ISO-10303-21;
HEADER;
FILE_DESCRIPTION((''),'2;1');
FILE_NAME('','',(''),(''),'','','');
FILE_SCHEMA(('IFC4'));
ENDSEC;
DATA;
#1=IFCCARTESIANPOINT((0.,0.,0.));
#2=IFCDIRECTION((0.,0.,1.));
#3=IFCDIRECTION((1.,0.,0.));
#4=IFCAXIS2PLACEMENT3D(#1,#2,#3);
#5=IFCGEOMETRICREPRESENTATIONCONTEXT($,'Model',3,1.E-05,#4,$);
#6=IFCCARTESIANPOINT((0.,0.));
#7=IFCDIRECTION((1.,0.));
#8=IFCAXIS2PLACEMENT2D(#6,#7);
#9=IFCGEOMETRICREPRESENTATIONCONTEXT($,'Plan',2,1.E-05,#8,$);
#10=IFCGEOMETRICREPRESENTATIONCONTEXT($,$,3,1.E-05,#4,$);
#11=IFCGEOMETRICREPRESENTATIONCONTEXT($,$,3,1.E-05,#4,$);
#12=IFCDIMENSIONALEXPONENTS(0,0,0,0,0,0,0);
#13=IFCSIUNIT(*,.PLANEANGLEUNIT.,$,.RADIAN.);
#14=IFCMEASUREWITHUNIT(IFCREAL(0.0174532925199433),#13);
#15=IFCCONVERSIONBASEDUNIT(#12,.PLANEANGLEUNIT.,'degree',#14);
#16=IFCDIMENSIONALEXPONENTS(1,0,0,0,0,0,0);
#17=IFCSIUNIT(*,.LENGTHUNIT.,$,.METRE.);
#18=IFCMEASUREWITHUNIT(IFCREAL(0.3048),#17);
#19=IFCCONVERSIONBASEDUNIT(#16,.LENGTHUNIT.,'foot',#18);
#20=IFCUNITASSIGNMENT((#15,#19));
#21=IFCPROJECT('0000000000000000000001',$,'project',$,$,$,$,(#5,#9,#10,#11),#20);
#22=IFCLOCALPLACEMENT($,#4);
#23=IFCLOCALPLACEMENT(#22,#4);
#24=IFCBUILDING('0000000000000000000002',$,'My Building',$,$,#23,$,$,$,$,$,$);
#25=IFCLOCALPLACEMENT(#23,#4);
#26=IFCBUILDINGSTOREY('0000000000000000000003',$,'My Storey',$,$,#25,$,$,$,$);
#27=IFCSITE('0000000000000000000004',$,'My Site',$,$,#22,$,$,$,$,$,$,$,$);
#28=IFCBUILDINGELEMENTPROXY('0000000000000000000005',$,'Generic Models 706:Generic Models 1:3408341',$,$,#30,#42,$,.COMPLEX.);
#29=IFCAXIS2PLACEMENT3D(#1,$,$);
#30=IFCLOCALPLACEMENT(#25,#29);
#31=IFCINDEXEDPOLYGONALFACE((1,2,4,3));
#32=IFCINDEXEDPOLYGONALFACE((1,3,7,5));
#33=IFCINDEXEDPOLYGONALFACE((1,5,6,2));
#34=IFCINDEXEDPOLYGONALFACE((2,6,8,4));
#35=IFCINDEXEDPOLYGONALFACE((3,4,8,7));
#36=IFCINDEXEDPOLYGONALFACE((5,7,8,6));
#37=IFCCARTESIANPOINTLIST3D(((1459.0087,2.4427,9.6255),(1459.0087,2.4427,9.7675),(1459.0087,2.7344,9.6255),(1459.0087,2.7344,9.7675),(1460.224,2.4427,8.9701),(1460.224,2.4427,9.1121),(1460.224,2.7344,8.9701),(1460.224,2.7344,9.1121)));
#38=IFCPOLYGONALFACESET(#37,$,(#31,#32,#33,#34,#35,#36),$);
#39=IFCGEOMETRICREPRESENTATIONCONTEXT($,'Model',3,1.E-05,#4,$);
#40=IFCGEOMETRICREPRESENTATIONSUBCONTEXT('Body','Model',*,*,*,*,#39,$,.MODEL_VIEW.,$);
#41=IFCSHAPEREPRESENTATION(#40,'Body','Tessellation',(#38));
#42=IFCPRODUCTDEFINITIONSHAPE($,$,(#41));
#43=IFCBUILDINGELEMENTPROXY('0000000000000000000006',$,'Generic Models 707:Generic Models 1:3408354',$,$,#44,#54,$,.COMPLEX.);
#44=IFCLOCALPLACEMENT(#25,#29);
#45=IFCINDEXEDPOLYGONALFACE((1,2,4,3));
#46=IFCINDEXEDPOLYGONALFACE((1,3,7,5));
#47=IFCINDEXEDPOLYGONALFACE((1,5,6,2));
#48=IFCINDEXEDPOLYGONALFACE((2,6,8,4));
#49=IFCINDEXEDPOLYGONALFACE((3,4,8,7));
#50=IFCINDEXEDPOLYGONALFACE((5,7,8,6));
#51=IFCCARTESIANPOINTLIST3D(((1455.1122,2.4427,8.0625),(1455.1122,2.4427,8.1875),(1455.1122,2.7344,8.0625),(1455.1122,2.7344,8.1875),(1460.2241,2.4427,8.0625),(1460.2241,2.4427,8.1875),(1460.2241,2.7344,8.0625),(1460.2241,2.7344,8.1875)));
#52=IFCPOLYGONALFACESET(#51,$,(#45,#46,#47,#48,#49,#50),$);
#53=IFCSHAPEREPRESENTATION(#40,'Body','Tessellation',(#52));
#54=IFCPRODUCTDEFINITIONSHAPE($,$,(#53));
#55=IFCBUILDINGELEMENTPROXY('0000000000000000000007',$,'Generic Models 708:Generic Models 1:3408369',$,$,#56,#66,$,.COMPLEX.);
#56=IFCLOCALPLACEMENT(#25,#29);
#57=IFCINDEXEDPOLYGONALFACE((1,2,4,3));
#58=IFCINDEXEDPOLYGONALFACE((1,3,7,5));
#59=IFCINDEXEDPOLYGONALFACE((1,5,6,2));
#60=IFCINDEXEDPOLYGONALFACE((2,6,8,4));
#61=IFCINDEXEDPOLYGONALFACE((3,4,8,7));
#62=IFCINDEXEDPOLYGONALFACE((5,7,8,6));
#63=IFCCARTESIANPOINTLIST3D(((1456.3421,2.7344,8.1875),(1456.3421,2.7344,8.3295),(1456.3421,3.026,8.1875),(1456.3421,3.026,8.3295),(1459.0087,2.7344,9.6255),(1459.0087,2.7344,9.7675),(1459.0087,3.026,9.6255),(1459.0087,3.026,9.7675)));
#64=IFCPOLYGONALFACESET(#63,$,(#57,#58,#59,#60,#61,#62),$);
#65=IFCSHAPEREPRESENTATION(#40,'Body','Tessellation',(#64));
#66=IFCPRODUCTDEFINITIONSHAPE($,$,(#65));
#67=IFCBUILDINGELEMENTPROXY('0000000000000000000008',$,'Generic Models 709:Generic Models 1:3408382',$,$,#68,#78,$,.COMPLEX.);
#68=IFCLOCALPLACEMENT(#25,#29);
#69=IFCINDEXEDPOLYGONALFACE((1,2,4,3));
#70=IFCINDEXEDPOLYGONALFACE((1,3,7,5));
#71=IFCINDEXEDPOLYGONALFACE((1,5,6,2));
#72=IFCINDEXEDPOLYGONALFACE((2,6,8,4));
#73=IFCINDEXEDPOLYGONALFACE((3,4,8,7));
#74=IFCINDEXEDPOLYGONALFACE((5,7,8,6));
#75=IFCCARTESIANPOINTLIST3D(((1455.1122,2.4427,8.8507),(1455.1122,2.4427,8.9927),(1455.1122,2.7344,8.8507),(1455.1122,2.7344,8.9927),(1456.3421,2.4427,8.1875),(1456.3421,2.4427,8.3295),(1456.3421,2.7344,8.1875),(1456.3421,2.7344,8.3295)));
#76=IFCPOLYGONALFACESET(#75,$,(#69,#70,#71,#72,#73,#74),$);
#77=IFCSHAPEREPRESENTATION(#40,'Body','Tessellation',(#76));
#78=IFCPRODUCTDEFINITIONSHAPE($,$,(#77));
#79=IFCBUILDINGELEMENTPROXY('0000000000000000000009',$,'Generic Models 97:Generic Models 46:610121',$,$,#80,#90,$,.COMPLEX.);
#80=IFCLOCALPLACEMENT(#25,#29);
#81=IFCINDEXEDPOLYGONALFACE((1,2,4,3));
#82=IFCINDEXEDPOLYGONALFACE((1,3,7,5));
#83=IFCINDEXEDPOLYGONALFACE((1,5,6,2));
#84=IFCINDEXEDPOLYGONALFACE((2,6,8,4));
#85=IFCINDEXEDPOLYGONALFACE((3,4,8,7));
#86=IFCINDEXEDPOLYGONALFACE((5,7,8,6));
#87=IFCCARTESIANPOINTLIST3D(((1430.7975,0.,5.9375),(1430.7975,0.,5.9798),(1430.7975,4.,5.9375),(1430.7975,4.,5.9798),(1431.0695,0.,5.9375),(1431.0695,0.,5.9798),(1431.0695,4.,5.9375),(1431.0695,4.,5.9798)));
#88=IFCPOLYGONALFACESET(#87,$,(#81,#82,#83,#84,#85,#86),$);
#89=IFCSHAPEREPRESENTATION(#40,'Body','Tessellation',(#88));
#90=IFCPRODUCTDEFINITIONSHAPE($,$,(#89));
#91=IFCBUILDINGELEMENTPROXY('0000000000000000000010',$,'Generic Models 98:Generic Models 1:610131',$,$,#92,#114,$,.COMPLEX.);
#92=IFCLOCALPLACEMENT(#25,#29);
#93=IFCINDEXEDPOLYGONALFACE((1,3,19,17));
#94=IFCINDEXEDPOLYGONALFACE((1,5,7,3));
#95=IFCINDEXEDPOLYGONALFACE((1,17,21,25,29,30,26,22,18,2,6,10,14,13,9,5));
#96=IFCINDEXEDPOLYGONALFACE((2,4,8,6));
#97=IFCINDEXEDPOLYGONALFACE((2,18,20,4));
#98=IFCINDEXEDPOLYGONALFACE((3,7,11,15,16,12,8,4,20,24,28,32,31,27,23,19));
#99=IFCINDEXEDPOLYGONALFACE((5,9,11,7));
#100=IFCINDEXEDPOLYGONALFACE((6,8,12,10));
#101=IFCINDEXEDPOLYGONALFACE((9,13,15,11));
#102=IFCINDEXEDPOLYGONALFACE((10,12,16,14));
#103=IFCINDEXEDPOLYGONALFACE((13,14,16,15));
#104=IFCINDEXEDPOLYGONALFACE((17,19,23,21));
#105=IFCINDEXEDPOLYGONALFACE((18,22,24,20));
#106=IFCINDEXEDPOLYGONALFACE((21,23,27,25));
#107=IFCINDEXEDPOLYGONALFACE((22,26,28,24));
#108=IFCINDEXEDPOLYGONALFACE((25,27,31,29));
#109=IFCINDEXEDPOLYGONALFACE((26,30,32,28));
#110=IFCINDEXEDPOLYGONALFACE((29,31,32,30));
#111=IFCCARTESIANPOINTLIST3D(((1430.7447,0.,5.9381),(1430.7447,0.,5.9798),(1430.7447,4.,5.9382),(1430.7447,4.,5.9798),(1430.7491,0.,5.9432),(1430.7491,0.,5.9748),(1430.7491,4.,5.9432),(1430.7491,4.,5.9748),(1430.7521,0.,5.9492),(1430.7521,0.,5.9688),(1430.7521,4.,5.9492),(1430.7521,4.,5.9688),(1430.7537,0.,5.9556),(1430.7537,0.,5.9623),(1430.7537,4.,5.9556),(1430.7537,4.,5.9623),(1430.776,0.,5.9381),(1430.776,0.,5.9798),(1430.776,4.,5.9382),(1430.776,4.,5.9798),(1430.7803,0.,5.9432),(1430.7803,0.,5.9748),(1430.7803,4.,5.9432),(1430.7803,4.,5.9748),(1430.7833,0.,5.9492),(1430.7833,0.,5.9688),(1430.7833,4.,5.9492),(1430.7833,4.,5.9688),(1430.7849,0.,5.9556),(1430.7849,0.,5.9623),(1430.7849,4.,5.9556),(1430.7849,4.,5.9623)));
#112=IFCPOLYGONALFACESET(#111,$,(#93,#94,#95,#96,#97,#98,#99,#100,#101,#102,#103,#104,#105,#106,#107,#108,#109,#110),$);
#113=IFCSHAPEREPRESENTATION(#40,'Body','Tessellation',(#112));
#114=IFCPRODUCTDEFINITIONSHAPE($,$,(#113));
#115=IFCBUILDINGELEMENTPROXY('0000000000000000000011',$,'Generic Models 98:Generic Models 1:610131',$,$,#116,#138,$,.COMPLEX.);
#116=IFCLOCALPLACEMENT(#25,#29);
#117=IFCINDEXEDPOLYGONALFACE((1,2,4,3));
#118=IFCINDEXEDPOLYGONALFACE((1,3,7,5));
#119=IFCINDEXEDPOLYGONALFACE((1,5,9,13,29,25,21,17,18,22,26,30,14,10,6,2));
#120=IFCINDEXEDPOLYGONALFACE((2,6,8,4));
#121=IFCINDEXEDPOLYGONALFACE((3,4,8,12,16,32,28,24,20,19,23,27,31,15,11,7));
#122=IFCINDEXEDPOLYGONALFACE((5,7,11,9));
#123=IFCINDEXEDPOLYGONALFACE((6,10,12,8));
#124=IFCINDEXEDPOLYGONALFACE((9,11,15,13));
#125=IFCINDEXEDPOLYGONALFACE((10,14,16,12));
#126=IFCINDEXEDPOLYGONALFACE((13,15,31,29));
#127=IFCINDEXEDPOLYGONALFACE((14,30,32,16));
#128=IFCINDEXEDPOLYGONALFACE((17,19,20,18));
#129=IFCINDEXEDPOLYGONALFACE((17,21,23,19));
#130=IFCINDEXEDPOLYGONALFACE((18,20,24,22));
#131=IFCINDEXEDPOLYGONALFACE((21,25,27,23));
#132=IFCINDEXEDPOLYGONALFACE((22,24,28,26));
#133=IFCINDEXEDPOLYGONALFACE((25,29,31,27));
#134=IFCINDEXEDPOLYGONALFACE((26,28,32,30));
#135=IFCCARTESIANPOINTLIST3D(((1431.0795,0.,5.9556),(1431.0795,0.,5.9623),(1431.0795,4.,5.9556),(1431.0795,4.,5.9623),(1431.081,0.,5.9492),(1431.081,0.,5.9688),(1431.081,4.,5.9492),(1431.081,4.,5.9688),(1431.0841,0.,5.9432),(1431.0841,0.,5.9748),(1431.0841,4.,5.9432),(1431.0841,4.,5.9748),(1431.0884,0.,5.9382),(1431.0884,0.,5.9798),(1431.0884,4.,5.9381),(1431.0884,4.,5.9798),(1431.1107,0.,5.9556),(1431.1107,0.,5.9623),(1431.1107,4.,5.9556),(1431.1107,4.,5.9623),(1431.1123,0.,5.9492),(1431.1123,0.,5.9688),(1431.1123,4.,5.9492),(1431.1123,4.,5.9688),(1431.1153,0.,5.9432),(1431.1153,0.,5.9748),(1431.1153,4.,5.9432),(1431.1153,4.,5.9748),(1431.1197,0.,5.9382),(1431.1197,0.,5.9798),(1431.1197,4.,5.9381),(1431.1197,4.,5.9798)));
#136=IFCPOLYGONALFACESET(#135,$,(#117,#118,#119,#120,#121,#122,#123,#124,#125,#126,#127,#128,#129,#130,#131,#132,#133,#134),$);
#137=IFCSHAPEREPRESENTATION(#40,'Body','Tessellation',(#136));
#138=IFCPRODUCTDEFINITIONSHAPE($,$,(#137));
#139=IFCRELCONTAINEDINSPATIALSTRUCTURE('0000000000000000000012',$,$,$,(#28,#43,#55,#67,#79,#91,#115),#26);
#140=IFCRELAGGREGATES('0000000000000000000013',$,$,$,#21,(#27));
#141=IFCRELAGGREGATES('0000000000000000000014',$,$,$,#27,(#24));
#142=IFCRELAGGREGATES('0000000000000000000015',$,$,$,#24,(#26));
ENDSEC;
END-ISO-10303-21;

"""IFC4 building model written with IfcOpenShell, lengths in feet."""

from ifc_helpers import new_model, entity, si_unit, converted_unit, frame, origin_with_axes, origin_2d_with_axis, place, context, subcontext, project, spatial, polyline, line, indexed_curve, outline, extrude, element, save


model = new_model("IFC4")

# Units and contexts
model_context_1 = context("Model", 3, precision=1e-05, world=origin_with_axes())
plan_context = context("Plan", 2, precision=1e-05, world=origin_2d_with_axis())
model_context_2 = context("Model", 3, precision=1e-05, world=origin_with_axes())
context_of_model_1 = context(None, 3, precision=1e-05, world=origin_with_axes())
context_of_model_2 = context(None, 3, precision=1e-05, world=origin_with_axes())
body_context_1 = subcontext(model_context_2, "Body", "Model", "MODEL_VIEW")
ifc_project = project(units=[converted_unit("PLANEANGLEUNIT", "degree", entity("IfcReal", 0.0174532925199433), si_unit("PLANEANGLEUNIT", "RADIAN"), dimensions=[0, 0, 0, 0, 0, 0, 0]), converted_unit("LENGTHUNIT", "foot", entity("IfcReal", 0.3048), si_unit("LENGTHUNIT", "METRE"), dimensions=[1, 0, 0, 0, 0, 0, 0])], contexts=[model_context_1, plan_context, context_of_model_1, context_of_model_2])

# Site, building, storey
site_placement = place(None, origin_with_axes())
site = spatial("IfcSite", under=ifc_project, at=site_placement, Name="My Site")
building_placement = place(site_placement, origin_with_axes())
building = spatial("IfcBuilding", under=site, at=building_placement, Name="My Building")
storey_placement = place(building_placement, origin_with_axes())
storey = spatial("IfcBuildingStorey", under=building, at=storey_placement, Name="My Storey")

# Building element proxies
proxy_1_placement = place(storey_placement, frame((1459.0087, 2.7344, 8.9701), z_axis=(0.0, -1.0, 0.0), x_axis=(1.0, 0.0, 0.0)))
element("IfcBuildingElementProxy", 1, at=proxy_1_placement, inside=storey, Name="Generic Models 706:Generic Models 1:3408341", PredefinedType="COMPLEX", context=body_context_1, shape_type="SweptSolid", body=[
    extrude(outline(polyline([(0.2567, -0.6077), (0.3987, -0.6077), (-0.2567, 0.6077), (-0.3987, 0.6077), (0.2567, -0.6077)])), frame((0.6077, 0.3987, 0.0), z_axis=(0.0, 0.0, -1.0), x_axis=(0.0, 1.0, 0.0)), (0.0, 0.0, -1.0), 0.2917),
])
proxy_2_placement = place(storey_placement, frame((1455.1122, 2.7344, 8.0625), z_axis=(0.0, -1.0, 0.0), x_axis=(1.0, 0.0, 0.0)))
element("IfcBuildingElementProxy", 2, at=proxy_2_placement, inside=storey, Name="Generic Models 707:Generic Models 1:3408354", PredefinedType="COMPLEX", context=body_context_1, shape_type="SweptSolid", body=[
    extrude(outline(polyline([(-0.0625, -2.556), (0.0625, -2.556), (0.0625, 2.556), (-0.0625, 2.556), (-0.0625, -2.556)])), frame((2.556, 0.0625, 0.0), z_axis=(0.0, 0.0, -1.0), x_axis=(0.0, 1.0, 0.0)), (0.0, 0.0, -1.0), 0.2917),
])
proxy_3_placement = place(storey_placement, frame((1456.3421, 3.026, 8.1875), z_axis=(0.0, -1.0, 0.0), x_axis=(1.0, 0.0, 0.0)))
element("IfcBuildingElementProxy", 3, at=proxy_3_placement, inside=storey, Name="Generic Models 708:Generic Models 1:3408369", PredefinedType="COMPLEX", context=body_context_1, shape_type="SweptSolid", body=[
    extrude(outline(polyline([(-0.79, -1.3333), (-0.648, -1.3333), (0.79, 1.3333), (0.648, 1.3333), (-0.79, -1.3333)])), frame((1.3333, 0.79, 0.0), z_axis=(0.0, 0.0, -1.0), x_axis=(0.0, -1.0, 0.0)), (0.0, 0.0, -1.0), 0.2917),
])
proxy_4_placement = place(storey_placement, frame((1455.1122, 2.7344, 8.1875), z_axis=(0.0, -1.0, 0.0), x_axis=(1.0, 0.0, 0.0)))
element("IfcBuildingElementProxy", 4, at=proxy_4_placement, inside=storey, Name="Generic Models 709:Generic Models 1:3408382", PredefinedType="COMPLEX", context=body_context_1, shape_type="SweptSolid", body=[
    extrude(outline(polyline([(0.2606, -0.6149), (0.4026, -0.6149), (-0.2606, 0.6149), (-0.4026, 0.6149), (0.2606, -0.6149)])), frame((0.6149, 0.4026, 0.0), z_axis=(0.0, 0.0, -1.0), x_axis=(0.0, 1.0, 0.0)), (0.0, 0.0, -1.0), 0.2917),
])
proxy_5_placement = place(storey_placement, frame((1430.7975, 4.0, 5.9375), z_axis=(0.0, -1.0, 0.0), x_axis=(0.0, 0.0, 1.0)))
element("IfcBuildingElementProxy", 5, at=proxy_5_placement, inside=storey, Name="Generic Models 97:Generic Models 46:610121", PredefinedType="COMPLEX", context=body_context_1, shape_type="SweptSolid", body=[
    extrude(outline(polyline([(-0.0212, -0.136), (0.0212, -0.136), (0.0212, 0.136), (-0.0212, 0.136), (-0.0212, -0.136)])), frame((0.0212, -0.136, 0.0), z_axis=(0.0, 0.0, -1.0), x_axis=(-1.0, 0.0, 0.0)), (0.0, 0.0, -1.0), 4.0),
])
proxy_6_placement = place(storey_placement, frame((1430.7849, 3.847, 5.9382), z_axis=(0.0, 1.0, 0.0), x_axis=(0.0, 0.0, 1.0)))
element("IfcBuildingElementProxy", 6, at=proxy_6_placement, inside=storey, Name="Generic Models 98:Generic Models 1:610131", PredefinedType="COMPLEX", context=body_context_1, shape_type="SweptSolid", body=[
    extrude(outline(indexed_curve([(0.0115, 0.0043), (0.0166, 0.0), (0.0226, -0.003), (0.0291, -0.0045), (0.0039, -0.023), (-0.0026, -0.0215), (-0.0086, -0.0185), (-0.0137, -0.0142), (-0.0176, -0.0088), (-0.0202, -0.0026), (-0.0213, 0.004), (-0.0207, 0.0106), (0.0045, 0.0291), (0.0039, 0.0224), (0.005, 0.0159), (0.0076, 0.0097)], segments=[line(12, 11), line(11, 10), line(10, 9), line(9, 8), line(8, 7), line(7, 6), line(6, 5), line(5, 4), line(4, 3), line(3, 2), line(2, 1), line(1, 16), line(16, 15), line(15, 14), line(14, 13), line(13, 12)], self_intersect=False)), frame((0.0208, -0.0194, 0.153), z_axis=(0.0, 0.0, -1.0), x_axis=(0.591192, -0.806531, 0.000001)), (-0.000001, 0.0, 1.0), 4.0),
])
proxy_7_placement = place(storey_placement, frame((1431.0795, 3.847, 5.9798), z_axis=(0.0, 1.0, 0.0), x_axis=(0.0, 0.0, -1.0)))
element("IfcBuildingElementProxy", 7, at=proxy_7_placement, inside=storey, Name="Generic Models 98:Generic Models 1:610131", PredefinedType="COMPLEX", context=body_context_1, shape_type="SweptSolid", body=[
    extrude(outline(indexed_curve([(0.0115, 0.0043), (0.0166, 0.0), (0.0226, -0.003), (0.0291, -0.0045), (0.0039, -0.023), (-0.0026, -0.0215), (-0.0086, -0.0185), (-0.0137, -0.0142), (-0.0176, -0.0088), (-0.0202, -0.0026), (-0.0213, 0.004), (-0.0207, 0.0106), (0.0045, 0.0291), (0.0039, 0.0224), (0.005, 0.0159), (0.0076, 0.0097)], segments=[line(9, 8), line(8, 7), line(7, 6), line(6, 5), line(5, 4), line(4, 3), line(3, 2), line(2, 1), line(1, 16), line(16, 15), line(15, 14), line(14, 13), line(13, 12), line(12, 11), line(11, 10), line(10, 9)], self_intersect=False)), frame((0.0208, -0.0194, 0.153), z_axis=(0.0, 0.0, -1.0), x_axis=(0.591192, -0.806531, 0.000001)), (-0.000001, 0.0, 1.0), 4.0),
])

save(model, "model.ifc")
